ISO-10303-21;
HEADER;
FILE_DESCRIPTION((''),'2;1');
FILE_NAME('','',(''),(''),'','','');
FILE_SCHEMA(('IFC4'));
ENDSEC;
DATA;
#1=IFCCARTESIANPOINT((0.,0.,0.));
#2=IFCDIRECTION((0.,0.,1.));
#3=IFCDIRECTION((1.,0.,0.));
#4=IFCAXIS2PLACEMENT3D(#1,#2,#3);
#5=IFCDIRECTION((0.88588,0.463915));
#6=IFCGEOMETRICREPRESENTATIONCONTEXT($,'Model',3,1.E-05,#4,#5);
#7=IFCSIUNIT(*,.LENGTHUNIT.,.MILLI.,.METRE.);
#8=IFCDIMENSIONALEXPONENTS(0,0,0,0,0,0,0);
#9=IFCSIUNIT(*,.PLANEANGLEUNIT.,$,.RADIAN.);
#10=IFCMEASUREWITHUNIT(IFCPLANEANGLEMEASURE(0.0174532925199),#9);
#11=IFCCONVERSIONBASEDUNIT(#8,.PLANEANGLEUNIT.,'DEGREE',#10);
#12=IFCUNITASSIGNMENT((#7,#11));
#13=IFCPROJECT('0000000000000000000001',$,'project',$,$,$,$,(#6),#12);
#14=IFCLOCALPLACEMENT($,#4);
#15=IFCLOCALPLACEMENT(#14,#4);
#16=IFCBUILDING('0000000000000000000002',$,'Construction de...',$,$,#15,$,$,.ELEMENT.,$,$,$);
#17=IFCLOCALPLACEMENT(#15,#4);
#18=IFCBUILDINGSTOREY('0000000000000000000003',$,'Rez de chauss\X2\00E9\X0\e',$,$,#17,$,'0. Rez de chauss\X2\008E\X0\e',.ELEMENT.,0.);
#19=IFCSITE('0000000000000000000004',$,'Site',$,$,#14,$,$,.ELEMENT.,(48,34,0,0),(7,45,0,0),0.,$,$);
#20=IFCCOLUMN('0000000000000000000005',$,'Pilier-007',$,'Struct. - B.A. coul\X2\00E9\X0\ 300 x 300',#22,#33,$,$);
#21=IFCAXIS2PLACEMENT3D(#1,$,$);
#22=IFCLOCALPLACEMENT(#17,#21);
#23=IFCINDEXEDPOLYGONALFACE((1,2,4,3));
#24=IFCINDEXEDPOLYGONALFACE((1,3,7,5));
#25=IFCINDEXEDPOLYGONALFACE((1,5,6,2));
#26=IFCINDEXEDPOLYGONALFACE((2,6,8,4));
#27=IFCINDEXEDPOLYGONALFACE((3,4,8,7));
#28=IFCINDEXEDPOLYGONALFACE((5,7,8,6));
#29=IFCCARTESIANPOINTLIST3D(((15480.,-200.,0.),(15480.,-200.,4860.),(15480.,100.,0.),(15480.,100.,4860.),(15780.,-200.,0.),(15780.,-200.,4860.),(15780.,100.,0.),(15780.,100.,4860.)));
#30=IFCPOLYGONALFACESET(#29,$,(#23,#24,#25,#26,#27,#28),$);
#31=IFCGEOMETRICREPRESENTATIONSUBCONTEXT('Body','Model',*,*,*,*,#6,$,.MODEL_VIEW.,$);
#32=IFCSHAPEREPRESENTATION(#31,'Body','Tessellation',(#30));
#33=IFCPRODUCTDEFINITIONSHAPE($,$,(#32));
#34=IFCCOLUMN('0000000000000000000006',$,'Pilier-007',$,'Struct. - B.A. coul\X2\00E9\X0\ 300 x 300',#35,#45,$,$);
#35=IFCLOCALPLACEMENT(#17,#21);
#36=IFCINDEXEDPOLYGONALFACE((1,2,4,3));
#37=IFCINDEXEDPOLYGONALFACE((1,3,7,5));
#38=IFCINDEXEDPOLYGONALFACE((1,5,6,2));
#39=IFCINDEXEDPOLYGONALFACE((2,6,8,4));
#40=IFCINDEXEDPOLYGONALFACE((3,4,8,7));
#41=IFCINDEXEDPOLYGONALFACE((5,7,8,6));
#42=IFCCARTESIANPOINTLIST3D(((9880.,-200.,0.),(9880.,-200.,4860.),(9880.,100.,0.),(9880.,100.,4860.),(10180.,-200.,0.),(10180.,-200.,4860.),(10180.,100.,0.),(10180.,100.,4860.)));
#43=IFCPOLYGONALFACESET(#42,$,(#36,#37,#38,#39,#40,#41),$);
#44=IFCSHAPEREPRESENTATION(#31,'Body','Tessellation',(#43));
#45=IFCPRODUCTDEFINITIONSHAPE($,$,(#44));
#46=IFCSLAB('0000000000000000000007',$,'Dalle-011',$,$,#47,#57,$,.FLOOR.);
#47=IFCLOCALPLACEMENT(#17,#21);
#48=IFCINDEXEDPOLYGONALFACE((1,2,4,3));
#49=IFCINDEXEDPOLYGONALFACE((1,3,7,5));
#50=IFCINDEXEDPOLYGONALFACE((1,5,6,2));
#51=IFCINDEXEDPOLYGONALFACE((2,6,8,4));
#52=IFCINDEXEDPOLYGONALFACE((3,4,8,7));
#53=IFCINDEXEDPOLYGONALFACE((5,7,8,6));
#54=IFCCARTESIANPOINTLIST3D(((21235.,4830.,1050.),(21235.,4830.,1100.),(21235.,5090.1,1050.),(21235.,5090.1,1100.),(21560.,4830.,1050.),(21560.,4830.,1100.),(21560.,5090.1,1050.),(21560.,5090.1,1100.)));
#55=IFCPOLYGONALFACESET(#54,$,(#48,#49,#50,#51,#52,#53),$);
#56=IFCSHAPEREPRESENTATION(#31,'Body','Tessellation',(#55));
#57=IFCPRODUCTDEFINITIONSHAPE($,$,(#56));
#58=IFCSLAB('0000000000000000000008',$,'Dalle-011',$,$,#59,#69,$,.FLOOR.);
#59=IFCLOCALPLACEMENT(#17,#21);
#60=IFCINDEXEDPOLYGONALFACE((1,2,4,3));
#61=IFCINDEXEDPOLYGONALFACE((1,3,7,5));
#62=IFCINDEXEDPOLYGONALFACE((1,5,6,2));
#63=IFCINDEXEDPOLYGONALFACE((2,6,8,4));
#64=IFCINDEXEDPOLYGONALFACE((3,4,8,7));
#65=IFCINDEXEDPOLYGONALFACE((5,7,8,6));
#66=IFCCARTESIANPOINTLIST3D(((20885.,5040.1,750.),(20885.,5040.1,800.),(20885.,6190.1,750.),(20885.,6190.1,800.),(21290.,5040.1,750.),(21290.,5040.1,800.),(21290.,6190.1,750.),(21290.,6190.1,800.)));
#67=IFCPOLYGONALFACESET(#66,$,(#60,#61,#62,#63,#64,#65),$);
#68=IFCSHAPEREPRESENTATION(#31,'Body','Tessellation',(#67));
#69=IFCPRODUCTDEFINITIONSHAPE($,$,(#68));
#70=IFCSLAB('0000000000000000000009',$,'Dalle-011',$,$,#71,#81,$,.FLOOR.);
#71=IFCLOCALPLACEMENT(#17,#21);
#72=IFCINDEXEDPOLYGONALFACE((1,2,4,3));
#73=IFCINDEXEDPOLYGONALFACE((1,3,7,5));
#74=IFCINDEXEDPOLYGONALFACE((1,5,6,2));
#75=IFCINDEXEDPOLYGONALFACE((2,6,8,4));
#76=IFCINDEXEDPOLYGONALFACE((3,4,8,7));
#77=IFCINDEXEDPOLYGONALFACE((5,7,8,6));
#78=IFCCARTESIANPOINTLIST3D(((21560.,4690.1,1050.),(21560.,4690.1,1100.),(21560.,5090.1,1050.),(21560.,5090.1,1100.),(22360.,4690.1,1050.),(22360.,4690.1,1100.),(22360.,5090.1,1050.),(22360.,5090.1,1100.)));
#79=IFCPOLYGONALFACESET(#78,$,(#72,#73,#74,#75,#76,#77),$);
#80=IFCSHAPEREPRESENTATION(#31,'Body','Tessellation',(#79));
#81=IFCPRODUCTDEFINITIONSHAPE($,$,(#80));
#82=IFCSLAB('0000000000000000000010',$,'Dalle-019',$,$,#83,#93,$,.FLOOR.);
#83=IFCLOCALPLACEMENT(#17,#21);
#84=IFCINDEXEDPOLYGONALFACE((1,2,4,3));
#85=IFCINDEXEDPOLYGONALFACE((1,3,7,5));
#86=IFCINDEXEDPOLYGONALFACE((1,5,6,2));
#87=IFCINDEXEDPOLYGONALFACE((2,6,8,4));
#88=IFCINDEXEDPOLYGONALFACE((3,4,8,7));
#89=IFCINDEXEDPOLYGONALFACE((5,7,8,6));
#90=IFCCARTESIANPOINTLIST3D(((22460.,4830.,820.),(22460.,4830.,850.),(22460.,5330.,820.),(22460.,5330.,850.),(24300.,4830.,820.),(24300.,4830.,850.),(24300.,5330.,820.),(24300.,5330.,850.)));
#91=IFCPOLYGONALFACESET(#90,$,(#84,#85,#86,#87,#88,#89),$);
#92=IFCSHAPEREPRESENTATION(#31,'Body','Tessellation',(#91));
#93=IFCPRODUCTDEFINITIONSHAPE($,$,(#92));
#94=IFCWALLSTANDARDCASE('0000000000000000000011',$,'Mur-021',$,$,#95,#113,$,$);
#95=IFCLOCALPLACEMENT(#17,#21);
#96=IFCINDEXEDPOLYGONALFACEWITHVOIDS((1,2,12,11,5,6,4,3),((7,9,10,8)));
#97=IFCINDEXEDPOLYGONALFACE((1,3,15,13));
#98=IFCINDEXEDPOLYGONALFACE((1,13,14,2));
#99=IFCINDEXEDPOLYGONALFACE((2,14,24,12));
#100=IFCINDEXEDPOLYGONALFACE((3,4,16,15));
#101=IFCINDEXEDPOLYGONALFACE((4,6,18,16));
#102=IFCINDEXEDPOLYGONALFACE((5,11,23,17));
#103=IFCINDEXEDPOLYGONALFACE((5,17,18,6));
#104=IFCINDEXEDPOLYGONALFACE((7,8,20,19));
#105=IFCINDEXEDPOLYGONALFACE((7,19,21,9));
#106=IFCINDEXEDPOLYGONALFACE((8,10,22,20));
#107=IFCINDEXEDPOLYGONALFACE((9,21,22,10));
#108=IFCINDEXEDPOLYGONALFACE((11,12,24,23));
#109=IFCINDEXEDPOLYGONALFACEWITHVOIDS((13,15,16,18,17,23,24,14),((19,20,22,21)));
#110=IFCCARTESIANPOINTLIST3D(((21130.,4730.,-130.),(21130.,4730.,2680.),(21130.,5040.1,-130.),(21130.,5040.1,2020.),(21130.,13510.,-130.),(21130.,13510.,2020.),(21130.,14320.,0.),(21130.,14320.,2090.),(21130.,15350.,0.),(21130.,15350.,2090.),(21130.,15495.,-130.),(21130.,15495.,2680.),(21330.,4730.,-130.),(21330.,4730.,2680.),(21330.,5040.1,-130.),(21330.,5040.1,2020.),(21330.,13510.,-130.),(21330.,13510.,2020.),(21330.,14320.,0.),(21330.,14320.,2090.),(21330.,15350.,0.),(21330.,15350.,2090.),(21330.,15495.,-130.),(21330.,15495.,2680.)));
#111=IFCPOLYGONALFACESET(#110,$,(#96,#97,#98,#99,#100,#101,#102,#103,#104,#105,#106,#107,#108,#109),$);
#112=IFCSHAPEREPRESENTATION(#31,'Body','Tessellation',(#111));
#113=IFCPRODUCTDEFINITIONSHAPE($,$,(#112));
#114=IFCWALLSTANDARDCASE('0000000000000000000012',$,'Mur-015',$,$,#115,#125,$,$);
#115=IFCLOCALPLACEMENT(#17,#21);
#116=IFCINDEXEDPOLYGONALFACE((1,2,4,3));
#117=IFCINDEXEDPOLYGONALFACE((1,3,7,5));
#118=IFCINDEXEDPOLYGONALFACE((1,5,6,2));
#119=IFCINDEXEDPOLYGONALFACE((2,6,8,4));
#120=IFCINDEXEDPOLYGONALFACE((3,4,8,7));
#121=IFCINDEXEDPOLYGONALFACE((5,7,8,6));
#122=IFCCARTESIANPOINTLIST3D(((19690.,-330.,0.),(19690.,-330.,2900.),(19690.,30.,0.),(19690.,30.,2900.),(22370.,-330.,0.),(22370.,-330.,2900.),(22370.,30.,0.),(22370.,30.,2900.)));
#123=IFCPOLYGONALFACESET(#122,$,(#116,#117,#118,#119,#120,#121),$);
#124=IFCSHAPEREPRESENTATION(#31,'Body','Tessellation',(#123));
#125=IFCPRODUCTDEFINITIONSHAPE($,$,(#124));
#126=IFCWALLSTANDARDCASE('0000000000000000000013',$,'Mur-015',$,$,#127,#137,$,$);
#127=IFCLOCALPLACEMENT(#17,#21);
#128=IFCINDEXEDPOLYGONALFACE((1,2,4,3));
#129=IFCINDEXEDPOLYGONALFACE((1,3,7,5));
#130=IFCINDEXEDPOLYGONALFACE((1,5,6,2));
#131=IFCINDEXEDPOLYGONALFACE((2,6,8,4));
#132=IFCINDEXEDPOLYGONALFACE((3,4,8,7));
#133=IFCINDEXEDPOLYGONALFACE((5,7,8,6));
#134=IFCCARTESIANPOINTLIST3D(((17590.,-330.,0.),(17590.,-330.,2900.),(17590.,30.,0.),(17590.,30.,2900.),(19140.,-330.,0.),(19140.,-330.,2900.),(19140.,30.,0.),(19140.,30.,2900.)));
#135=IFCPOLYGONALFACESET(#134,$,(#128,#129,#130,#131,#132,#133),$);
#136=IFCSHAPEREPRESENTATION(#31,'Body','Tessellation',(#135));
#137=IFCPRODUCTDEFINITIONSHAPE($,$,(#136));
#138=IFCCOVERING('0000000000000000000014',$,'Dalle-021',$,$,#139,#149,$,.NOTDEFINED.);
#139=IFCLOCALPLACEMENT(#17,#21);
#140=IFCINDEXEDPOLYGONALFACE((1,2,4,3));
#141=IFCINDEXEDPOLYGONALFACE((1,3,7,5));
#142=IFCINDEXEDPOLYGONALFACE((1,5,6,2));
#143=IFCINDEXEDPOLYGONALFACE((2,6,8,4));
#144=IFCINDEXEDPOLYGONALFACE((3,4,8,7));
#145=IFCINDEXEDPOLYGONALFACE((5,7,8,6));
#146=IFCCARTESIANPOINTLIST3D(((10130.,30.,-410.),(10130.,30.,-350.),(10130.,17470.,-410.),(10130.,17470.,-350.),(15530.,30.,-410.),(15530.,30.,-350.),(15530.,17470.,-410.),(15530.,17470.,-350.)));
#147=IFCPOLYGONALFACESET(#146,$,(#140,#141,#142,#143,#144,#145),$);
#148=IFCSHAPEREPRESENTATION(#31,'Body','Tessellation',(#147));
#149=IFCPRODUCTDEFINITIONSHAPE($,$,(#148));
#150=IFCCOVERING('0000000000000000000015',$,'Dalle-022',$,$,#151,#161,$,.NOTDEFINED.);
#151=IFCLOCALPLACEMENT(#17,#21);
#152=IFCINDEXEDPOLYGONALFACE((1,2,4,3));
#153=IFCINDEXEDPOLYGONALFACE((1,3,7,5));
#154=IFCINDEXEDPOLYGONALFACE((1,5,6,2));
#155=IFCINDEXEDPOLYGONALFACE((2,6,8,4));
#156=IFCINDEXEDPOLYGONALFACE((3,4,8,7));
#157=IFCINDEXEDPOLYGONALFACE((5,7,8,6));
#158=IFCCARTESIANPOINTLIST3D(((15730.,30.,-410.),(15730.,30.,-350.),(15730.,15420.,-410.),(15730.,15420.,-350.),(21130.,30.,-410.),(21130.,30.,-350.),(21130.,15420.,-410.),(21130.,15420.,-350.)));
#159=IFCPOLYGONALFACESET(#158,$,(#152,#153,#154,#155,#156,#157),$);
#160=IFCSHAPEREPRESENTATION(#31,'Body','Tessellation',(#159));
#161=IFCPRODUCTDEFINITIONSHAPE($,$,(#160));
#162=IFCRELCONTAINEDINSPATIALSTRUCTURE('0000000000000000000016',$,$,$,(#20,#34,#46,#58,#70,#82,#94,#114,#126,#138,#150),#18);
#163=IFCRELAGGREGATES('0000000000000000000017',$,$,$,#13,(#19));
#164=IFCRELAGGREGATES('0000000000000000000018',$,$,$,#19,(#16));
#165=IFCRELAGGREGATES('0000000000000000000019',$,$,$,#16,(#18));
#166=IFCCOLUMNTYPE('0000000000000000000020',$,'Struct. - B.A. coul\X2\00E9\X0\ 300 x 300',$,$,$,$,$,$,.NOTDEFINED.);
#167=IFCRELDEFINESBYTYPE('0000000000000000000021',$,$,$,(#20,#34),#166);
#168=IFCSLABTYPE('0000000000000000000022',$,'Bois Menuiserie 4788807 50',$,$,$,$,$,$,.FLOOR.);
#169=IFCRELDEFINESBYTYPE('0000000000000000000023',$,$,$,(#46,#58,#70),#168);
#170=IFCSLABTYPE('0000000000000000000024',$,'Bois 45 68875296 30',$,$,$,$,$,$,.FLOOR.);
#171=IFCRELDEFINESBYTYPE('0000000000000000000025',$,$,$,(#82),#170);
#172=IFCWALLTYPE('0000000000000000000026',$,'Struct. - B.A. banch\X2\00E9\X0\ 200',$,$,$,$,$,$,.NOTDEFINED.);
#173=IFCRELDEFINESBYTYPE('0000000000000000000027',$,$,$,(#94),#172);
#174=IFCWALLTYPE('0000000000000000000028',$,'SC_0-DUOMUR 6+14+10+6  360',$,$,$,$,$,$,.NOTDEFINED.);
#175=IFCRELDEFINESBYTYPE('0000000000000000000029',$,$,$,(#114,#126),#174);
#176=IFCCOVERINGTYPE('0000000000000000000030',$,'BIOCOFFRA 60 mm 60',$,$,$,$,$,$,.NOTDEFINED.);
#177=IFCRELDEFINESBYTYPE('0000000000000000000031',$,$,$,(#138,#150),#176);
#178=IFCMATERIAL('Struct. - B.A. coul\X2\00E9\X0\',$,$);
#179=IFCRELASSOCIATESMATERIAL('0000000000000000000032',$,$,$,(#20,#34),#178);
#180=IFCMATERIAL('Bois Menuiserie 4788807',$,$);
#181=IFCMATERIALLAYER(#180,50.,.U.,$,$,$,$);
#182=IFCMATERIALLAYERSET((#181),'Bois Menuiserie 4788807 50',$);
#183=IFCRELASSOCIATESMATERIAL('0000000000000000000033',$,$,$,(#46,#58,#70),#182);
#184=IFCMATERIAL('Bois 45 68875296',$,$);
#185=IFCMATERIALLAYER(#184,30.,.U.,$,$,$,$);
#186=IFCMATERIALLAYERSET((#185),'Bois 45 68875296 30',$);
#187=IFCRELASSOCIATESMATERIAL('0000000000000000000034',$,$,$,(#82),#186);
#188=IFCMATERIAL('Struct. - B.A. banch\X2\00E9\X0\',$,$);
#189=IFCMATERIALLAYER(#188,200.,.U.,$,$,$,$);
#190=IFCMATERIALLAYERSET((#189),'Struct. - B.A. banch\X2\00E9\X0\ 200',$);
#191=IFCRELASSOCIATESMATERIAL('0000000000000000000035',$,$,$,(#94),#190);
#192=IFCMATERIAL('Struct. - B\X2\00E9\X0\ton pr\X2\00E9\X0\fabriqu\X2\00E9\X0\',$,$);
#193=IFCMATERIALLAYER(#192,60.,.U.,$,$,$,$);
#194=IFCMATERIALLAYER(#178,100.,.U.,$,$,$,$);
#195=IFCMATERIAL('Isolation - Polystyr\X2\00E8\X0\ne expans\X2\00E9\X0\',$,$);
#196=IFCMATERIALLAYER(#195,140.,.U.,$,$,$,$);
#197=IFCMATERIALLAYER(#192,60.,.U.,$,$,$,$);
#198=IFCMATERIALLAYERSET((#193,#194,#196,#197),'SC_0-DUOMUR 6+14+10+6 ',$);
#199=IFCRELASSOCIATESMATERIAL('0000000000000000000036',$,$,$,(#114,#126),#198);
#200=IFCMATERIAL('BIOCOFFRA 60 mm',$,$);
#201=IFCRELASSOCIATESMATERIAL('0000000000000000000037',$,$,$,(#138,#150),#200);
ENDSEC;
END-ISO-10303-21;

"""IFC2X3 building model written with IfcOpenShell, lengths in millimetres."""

from ifc_helpers import new_model, entity, si_unit, converted_unit, direction, frame, origin_with_axes, origin_2d_with_axis, place, context, subcontext, project, spatial, polyline, rectangle, outline, extrude, clip, halfspace, material, layer, layer_set, layer_usage, type_object, element, save


model = new_model("IFC2X3")

# Units and contexts
model_context = context("Model", 3, precision=1e-05, world=origin_with_axes(), true_north=direction((0.88588, 0.463915)))
body_context = subcontext(model_context, "Body", "Model", "MODEL_VIEW")
ifc_project = project(units=[si_unit("LENGTHUNIT", "METRE", prefix="MILLI"), converted_unit("PLANEANGLEUNIT", "DEGREE", entity("IfcPlaneAngleMeasure", 0.0174532925199), si_unit("PLANEANGLEUNIT", "RADIAN"), dimensions=[0, 0, 0, 0, 0, 0, 0])], contexts=[model_context])

# Site, building, storey
site_placement = place(None, origin_with_axes())
site = spatial("IfcSite", under=ifc_project, at=site_placement, Name="Site", CompositionType="ELEMENT", RefLatitude=(48, 34, 0, 0), RefLongitude=(7, 45, 0, 0), RefElevation=0.0)
building_placement = place(site_placement, origin_with_axes())
building = spatial("IfcBuilding", under=site, at=building_placement, Name="Construction de...", CompositionType="ELEMENT")
storey_placement = place(building_placement, origin_with_axes())
storey = spatial("IfcBuildingStorey", under=building, at=storey_placement, Name="Rez de chaussée", LongName="0. Rez de chauss\u008ee", CompositionType="ELEMENT", Elevation=0.0)

# Columns
ifc_material_1 = material(Name="Struct. - B.A. coulé")
column_type = type_object("IfcColumnType", Name="Struct. - B.A. coulé 300 x 300", PredefinedType="NOTDEFINED")
for number, where, z_axis, x_axis, name in (
    (1, (15630.0, -50.0, 0.0), (0.0, 0.0, 1.0), (1.0, 0.0, 0.0), "Pilier-007"),
    (2, (10030.0, -50.0, 0.0), (0.0, 0.0, 1.0), (1.0, 0.0, 0.0), "Pilier-007"),
):
    element("IfcColumn", number, at=place(storey_placement, frame(where, z_axis=z_axis, x_axis=x_axis)), inside=storey, type_object=column_type, material=ifc_material_1, Name=name, ObjectType="Struct. - B.A. coulé 300 x 300", context=body_context, shape_type="SweptSolid", body=[
        extrude(rectangle(XDim=300.0, YDim=300.0, at=origin_2d_with_axis()), origin_with_axes(), (0.0, 0.0, 1.0), 4860.0),
    ])

# Slabs
ifc_material_2 = material(Name="Bois Menuiserie 4788807")
ifc_layer_1 = layer(ifc_material_2, 50.0, ventilated="UNKNOWN")
ifc_layer_set_1 = layer_set([ifc_layer_1], Name="Bois Menuiserie 4788807 50")
ifc_layer_usage_1 = layer_usage(ifc_layer_set_1, "AXIS3", "NEGATIVE", 50.0)
slab_type_1 = type_object("IfcSlabType", Name="Bois Menuiserie 4788807 50", PredefinedType="FLOOR")
slab_1_placement = place(storey_placement, frame((21235.0, 5090.1, 1100.0), z_axis=(0.0, 0.0, 1.0), x_axis=(1.0, 0.0, 0.0)))
element("IfcSlab", 3, at=slab_1_placement, inside=storey, type_object=slab_type_1, material=ifc_layer_usage_1, Name="Dalle-011", PredefinedType="FLOOR", context=body_context, shape_type="SweptSolid", body=[
    extrude(outline(polyline([(0.0, 0.0), (0.0, -260.1), (325.0, -260.1), (325.0, 0.0), (0.0, 0.0)])), frame((0.0, 0.0, -50.0), z_axis=(0.0, 0.0, 1.0), x_axis=(1.0, 0.0, 0.0)), (0.0, 0.0, 1.0), 50.0),
])
ifc_layer_usage_2 = layer_usage(ifc_layer_set_1, "AXIS3", "NEGATIVE", 50.0)
slab_2_placement = place(storey_placement, frame((21290.0, 5040.1, 800.0), z_axis=(0.0, 0.0, 1.0), x_axis=(1.0, 0.0, 0.0)))
element("IfcSlab", 4, at=slab_2_placement, inside=storey, type_object=slab_type_1, material=ifc_layer_usage_2, Name="Dalle-011", PredefinedType="FLOOR", context=body_context, shape_type="SweptSolid", body=[
    extrude(outline(polyline([(0.0, 0.0), (0.0, 1150.0), (-405.0, 1150.0), (-405.0, 0.0), (0.0, 0.0)])), frame((0.0, 0.0, -50.0), z_axis=(0.0, 0.0, 1.0), x_axis=(1.0, 0.0, 0.0)), (0.0, 0.0, 1.0), 50.0),
])
ifc_layer_usage_3 = layer_usage(ifc_layer_set_1, "AXIS3", "NEGATIVE", 50.0)
slab_3_placement = place(storey_placement, frame((21560.0, 4690.1, 1100.0), z_axis=(0.0, 0.0, 1.0), x_axis=(1.0, 0.0, 0.0)))
element("IfcSlab", 5, at=slab_3_placement, inside=storey, type_object=slab_type_1, material=ifc_layer_usage_3, Name="Dalle-011", PredefinedType="FLOOR", context=body_context, shape_type="SweptSolid", body=[
    extrude(outline(polyline([(0.0, 0.0), (800.0, 0.0), (800.0, 400.0), (0.0, 400.0), (0.0, 0.0)])), frame((0.0, 0.0, -50.0), z_axis=(0.0, 0.0, 1.0), x_axis=(1.0, 0.0, 0.0)), (0.0, 0.0, 1.0), 50.0),
])
ifc_material_3 = material(Name="Bois 45 68875296")
ifc_layer_2 = layer(ifc_material_3, 30.0, ventilated="UNKNOWN")
ifc_layer_set_2 = layer_set([ifc_layer_2], Name="Bois 45 68875296 30")
ifc_layer_usage_4 = layer_usage(ifc_layer_set_2, "AXIS3", "NEGATIVE", 30.0)
slab_type_2 = type_object("IfcSlabType", Name="Bois 45 68875296 30", PredefinedType="FLOOR")
slab_4_placement = place(storey_placement, frame((24300.0, 5330.0, 850.0), z_axis=(0.0, 0.0, 1.0), x_axis=(1.0, 0.0, 0.0)))
element("IfcSlab", 6, at=slab_4_placement, inside=storey, type_object=slab_type_2, material=ifc_layer_usage_4, Name="Dalle-019", PredefinedType="FLOOR", context=body_context, shape_type="SweptSolid", body=[
    extrude(outline(polyline([(0.0, 0.0), (-1840.0, 0.0), (-1840.0, -500.0), (0.0, -500.0), (0.0, 0.0)])), frame((0.0, 0.0, -30.0), z_axis=(0.0, 0.0, 1.0), x_axis=(1.0, 0.0, 0.0)), (0.0, 0.0, 1.0), 30.0),
])

# Wall, openings
ifc_material_4 = material(Name="Struct. - B.A. banché")
ifc_layer_3 = layer(ifc_material_4, 200.0, ventilated="UNKNOWN")
ifc_layer_set_3 = layer_set([ifc_layer_3], Name="Struct. - B.A. banché 200")
wall_type_1 = type_object("IfcWallType", Name="Struct. - B.A. banché 200", PredefinedType="NOTDEFINED")
ifc_layer_usage_5 = layer_usage(ifc_layer_set_3, "AXIS2", "NEGATIVE", 100.0)
wall_1_placement = place(storey_placement, frame((21230.0, 4730.0, -130.0), z_axis=(0.0, 0.0, 1.0), x_axis=(0.0, 1.0, 0.0)))
wall_1 = element("IfcWallStandardCase", 7, at=wall_1_placement, inside=storey, type_object=wall_type_1, material=ifc_layer_usage_5, Name="Mur-021", context=body_context, shape_type="SweptSolid", body=[
    extrude(outline(polyline([(0.0, -100.0), (10765.0, -100.0), (10765.0, 100.0), (0.0, 100.0), (0.0, -100.0)])), origin_with_axes(), (0.0, 0.0, 1.0), 2810.0),
])
opening_1_placement = place(wall_1_placement, frame((10105.0, 0.0, 130.0), z_axis=(0.0, 0.0, 1.0), x_axis=(1.0, 0.0, 0.0)))
element("IfcOpeningElement", 8, at=opening_1_placement, cuts=wall_1, context=body_context, shape_type="SweptSolid", body=[
    extrude(rectangle(XDim=1030.0, YDim=2090.0, at=origin_2d_with_axis()), frame((0.0, -200.0, 1045.0), z_axis=(0.0, 1.0, 0.0), x_axis=(1.0, 0.0, 0.0)), (0.0, 0.0, 1.0), 600.0),
])
opening_2_placement = place(wall_1_placement, frame((4545.0, 0.0, 0.0), z_axis=(0.0, 0.0, 1.0), x_axis=(1.0, 0.0, 0.0)))
element("IfcOpeningElement", 9, at=opening_2_placement, cuts=wall_1, context=body_context, shape_type="SweptSolid", body=[
    extrude(rectangle(XDim=8469.9, YDim=2150.0, at=origin_2d_with_axis()), frame((0.0, -100.0, 1075.0), z_axis=(0.0, 1.0, 0.0), x_axis=(1.0, 0.0, 0.0)), (0.0, 0.0, -1.0), 200.0),
    extrude(rectangle(XDim=8469.9, YDim=2150.0, at=origin_2d_with_axis()), frame((0.0, -100.0, 1075.0), z_axis=(0.0, -1.0, 0.0), x_axis=(1.0, 0.0, 0.0)), (0.0, 0.0, -1.0), 200.0),
])

# Walls
ifc_material_5 = material(Name="Struct. - Béton préfabriqué")
ifc_layer_4 = layer(ifc_material_5, 60.0, ventilated="UNKNOWN")
ifc_layer_5 = layer(ifc_material_1, 100.0, ventilated="UNKNOWN")
ifc_material_6 = material(Name="Isolation - Polystyrène expansé")
ifc_layer_6 = layer(ifc_material_6, 140.0, ventilated="UNKNOWN")
ifc_layer_7 = layer(ifc_material_5, 60.0, ventilated="UNKNOWN")
ifc_layer_set_4 = layer_set([ifc_layer_4, ifc_layer_5, ifc_layer_6, ifc_layer_7], Name="SC_0-DUOMUR 6+14+10+6 ")
ifc_layer_usage_6 = layer_usage(ifc_layer_set_4, "AXIS2", "NEGATIVE", 180.0)
wall_type_2 = type_object("IfcWallType", Name="SC_0-DUOMUR 6+14+10+6  360", PredefinedType="NOTDEFINED")
wall_2_placement = place(storey_placement, frame((19690.0, -150.0, 0.0), z_axis=(0.0, 0.0, 1.0), x_axis=(1.0, 0.0, 0.0)))
element("IfcWallStandardCase", 10, at=wall_2_placement, inside=storey, type_object=wall_type_2, material=ifc_layer_usage_6, Name="Mur-015", context=body_context, shape_type="Clipping", body=[
    clip(extrude(outline(polyline([(0.0, -180.0), (2680.0, -180.0), (2680.0, 180.0), (0.0, 180.0), (0.0, -180.0)])), origin_with_axes(), (0.0, 0.0, 1.0), 2900.0), halfspace(frame((-227.7, 0.0, 6071.1), z_axis=(0.037474, 0.0, -0.999298), x_axis=(0.0, 1.0, 0.0)), True)),
])
ifc_layer_usage_7 = layer_usage(ifc_layer_set_4, "AXIS2", "NEGATIVE", 180.0)
wall_3_placement = place(storey_placement, frame((17590.0, -150.0, 0.0), z_axis=(0.0, 0.0, 1.0), x_axis=(1.0, 0.0, 0.0)))
element("IfcWallStandardCase", 11, at=wall_3_placement, inside=storey, type_object=wall_type_2, material=ifc_layer_usage_7, Name="Mur-015", context=body_context, shape_type="Clipping", body=[
    clip(extrude(outline(polyline([(0.0, -180.0), (1550.0, -180.0), (1550.0, 180.0), (0.0, 180.0), (0.0, -180.0)])), origin_with_axes(), (0.0, 0.0, 1.0), 2900.0), halfspace(frame((-224.7, 0.0, 5992.4), z_axis=(0.037474, 0.0, -0.999298), x_axis=(0.0, 1.0, 0.0)), True)),
])

# Coverings
ifc_material_7 = material(Name="BIOCOFFRA 60 mm")
covering_type_1 = type_object("IfcCoveringType", Name="BIOCOFFRA 60 mm 60", PredefinedType="NOTDEFINED")
covering_1_placement = place(storey_placement, frame((10130.0, 30.0, -350.0), z_axis=(0.0, 0.0, 1.0), x_axis=(1.0, 0.0, 0.0)))
element("IfcCovering", 12, at=covering_1_placement, inside=storey, type_object=covering_type_1, material=ifc_material_7, Name="Dalle-021", PredefinedType="NOTDEFINED", context=body_context, shape_type="SweptSolid", body=[
    extrude(outline(polyline([(0.0, 0.0), (5400.0, 0.0), (5400.0, 17440.0), (0.0, 17440.0), (0.0, 0.0)])), frame((0.0, 0.0, -60.0), z_axis=(0.0, 0.0, 1.0), x_axis=(1.0, 0.0, 0.0)), (0.0, 0.0, 1.0), 60.0),
])
covering_2_placement = place(storey_placement, frame((15730.0, 30.0, -350.0), z_axis=(0.0, 0.0, 1.0), x_axis=(1.0, 0.0, 0.0)))
element("IfcCovering", 13, at=covering_2_placement, inside=storey, type_object=covering_type_1, material=ifc_material_7, Name="Dalle-022", PredefinedType="NOTDEFINED", context=body_context, shape_type="SweptSolid", body=[
    extrude(outline(polyline([(0.0, 0.0), (5400.0, 0.0), (5400.0, 15390.0), (0.0, 15390.0), (0.0, 0.0)])), frame((0.0, 0.0, -60.0), z_axis=(0.0, 0.0, 1.0), x_axis=(1.0, 0.0, 0.0)), (0.0, 0.0, 1.0), 60.0),
])

save(model, "model.ifc")
